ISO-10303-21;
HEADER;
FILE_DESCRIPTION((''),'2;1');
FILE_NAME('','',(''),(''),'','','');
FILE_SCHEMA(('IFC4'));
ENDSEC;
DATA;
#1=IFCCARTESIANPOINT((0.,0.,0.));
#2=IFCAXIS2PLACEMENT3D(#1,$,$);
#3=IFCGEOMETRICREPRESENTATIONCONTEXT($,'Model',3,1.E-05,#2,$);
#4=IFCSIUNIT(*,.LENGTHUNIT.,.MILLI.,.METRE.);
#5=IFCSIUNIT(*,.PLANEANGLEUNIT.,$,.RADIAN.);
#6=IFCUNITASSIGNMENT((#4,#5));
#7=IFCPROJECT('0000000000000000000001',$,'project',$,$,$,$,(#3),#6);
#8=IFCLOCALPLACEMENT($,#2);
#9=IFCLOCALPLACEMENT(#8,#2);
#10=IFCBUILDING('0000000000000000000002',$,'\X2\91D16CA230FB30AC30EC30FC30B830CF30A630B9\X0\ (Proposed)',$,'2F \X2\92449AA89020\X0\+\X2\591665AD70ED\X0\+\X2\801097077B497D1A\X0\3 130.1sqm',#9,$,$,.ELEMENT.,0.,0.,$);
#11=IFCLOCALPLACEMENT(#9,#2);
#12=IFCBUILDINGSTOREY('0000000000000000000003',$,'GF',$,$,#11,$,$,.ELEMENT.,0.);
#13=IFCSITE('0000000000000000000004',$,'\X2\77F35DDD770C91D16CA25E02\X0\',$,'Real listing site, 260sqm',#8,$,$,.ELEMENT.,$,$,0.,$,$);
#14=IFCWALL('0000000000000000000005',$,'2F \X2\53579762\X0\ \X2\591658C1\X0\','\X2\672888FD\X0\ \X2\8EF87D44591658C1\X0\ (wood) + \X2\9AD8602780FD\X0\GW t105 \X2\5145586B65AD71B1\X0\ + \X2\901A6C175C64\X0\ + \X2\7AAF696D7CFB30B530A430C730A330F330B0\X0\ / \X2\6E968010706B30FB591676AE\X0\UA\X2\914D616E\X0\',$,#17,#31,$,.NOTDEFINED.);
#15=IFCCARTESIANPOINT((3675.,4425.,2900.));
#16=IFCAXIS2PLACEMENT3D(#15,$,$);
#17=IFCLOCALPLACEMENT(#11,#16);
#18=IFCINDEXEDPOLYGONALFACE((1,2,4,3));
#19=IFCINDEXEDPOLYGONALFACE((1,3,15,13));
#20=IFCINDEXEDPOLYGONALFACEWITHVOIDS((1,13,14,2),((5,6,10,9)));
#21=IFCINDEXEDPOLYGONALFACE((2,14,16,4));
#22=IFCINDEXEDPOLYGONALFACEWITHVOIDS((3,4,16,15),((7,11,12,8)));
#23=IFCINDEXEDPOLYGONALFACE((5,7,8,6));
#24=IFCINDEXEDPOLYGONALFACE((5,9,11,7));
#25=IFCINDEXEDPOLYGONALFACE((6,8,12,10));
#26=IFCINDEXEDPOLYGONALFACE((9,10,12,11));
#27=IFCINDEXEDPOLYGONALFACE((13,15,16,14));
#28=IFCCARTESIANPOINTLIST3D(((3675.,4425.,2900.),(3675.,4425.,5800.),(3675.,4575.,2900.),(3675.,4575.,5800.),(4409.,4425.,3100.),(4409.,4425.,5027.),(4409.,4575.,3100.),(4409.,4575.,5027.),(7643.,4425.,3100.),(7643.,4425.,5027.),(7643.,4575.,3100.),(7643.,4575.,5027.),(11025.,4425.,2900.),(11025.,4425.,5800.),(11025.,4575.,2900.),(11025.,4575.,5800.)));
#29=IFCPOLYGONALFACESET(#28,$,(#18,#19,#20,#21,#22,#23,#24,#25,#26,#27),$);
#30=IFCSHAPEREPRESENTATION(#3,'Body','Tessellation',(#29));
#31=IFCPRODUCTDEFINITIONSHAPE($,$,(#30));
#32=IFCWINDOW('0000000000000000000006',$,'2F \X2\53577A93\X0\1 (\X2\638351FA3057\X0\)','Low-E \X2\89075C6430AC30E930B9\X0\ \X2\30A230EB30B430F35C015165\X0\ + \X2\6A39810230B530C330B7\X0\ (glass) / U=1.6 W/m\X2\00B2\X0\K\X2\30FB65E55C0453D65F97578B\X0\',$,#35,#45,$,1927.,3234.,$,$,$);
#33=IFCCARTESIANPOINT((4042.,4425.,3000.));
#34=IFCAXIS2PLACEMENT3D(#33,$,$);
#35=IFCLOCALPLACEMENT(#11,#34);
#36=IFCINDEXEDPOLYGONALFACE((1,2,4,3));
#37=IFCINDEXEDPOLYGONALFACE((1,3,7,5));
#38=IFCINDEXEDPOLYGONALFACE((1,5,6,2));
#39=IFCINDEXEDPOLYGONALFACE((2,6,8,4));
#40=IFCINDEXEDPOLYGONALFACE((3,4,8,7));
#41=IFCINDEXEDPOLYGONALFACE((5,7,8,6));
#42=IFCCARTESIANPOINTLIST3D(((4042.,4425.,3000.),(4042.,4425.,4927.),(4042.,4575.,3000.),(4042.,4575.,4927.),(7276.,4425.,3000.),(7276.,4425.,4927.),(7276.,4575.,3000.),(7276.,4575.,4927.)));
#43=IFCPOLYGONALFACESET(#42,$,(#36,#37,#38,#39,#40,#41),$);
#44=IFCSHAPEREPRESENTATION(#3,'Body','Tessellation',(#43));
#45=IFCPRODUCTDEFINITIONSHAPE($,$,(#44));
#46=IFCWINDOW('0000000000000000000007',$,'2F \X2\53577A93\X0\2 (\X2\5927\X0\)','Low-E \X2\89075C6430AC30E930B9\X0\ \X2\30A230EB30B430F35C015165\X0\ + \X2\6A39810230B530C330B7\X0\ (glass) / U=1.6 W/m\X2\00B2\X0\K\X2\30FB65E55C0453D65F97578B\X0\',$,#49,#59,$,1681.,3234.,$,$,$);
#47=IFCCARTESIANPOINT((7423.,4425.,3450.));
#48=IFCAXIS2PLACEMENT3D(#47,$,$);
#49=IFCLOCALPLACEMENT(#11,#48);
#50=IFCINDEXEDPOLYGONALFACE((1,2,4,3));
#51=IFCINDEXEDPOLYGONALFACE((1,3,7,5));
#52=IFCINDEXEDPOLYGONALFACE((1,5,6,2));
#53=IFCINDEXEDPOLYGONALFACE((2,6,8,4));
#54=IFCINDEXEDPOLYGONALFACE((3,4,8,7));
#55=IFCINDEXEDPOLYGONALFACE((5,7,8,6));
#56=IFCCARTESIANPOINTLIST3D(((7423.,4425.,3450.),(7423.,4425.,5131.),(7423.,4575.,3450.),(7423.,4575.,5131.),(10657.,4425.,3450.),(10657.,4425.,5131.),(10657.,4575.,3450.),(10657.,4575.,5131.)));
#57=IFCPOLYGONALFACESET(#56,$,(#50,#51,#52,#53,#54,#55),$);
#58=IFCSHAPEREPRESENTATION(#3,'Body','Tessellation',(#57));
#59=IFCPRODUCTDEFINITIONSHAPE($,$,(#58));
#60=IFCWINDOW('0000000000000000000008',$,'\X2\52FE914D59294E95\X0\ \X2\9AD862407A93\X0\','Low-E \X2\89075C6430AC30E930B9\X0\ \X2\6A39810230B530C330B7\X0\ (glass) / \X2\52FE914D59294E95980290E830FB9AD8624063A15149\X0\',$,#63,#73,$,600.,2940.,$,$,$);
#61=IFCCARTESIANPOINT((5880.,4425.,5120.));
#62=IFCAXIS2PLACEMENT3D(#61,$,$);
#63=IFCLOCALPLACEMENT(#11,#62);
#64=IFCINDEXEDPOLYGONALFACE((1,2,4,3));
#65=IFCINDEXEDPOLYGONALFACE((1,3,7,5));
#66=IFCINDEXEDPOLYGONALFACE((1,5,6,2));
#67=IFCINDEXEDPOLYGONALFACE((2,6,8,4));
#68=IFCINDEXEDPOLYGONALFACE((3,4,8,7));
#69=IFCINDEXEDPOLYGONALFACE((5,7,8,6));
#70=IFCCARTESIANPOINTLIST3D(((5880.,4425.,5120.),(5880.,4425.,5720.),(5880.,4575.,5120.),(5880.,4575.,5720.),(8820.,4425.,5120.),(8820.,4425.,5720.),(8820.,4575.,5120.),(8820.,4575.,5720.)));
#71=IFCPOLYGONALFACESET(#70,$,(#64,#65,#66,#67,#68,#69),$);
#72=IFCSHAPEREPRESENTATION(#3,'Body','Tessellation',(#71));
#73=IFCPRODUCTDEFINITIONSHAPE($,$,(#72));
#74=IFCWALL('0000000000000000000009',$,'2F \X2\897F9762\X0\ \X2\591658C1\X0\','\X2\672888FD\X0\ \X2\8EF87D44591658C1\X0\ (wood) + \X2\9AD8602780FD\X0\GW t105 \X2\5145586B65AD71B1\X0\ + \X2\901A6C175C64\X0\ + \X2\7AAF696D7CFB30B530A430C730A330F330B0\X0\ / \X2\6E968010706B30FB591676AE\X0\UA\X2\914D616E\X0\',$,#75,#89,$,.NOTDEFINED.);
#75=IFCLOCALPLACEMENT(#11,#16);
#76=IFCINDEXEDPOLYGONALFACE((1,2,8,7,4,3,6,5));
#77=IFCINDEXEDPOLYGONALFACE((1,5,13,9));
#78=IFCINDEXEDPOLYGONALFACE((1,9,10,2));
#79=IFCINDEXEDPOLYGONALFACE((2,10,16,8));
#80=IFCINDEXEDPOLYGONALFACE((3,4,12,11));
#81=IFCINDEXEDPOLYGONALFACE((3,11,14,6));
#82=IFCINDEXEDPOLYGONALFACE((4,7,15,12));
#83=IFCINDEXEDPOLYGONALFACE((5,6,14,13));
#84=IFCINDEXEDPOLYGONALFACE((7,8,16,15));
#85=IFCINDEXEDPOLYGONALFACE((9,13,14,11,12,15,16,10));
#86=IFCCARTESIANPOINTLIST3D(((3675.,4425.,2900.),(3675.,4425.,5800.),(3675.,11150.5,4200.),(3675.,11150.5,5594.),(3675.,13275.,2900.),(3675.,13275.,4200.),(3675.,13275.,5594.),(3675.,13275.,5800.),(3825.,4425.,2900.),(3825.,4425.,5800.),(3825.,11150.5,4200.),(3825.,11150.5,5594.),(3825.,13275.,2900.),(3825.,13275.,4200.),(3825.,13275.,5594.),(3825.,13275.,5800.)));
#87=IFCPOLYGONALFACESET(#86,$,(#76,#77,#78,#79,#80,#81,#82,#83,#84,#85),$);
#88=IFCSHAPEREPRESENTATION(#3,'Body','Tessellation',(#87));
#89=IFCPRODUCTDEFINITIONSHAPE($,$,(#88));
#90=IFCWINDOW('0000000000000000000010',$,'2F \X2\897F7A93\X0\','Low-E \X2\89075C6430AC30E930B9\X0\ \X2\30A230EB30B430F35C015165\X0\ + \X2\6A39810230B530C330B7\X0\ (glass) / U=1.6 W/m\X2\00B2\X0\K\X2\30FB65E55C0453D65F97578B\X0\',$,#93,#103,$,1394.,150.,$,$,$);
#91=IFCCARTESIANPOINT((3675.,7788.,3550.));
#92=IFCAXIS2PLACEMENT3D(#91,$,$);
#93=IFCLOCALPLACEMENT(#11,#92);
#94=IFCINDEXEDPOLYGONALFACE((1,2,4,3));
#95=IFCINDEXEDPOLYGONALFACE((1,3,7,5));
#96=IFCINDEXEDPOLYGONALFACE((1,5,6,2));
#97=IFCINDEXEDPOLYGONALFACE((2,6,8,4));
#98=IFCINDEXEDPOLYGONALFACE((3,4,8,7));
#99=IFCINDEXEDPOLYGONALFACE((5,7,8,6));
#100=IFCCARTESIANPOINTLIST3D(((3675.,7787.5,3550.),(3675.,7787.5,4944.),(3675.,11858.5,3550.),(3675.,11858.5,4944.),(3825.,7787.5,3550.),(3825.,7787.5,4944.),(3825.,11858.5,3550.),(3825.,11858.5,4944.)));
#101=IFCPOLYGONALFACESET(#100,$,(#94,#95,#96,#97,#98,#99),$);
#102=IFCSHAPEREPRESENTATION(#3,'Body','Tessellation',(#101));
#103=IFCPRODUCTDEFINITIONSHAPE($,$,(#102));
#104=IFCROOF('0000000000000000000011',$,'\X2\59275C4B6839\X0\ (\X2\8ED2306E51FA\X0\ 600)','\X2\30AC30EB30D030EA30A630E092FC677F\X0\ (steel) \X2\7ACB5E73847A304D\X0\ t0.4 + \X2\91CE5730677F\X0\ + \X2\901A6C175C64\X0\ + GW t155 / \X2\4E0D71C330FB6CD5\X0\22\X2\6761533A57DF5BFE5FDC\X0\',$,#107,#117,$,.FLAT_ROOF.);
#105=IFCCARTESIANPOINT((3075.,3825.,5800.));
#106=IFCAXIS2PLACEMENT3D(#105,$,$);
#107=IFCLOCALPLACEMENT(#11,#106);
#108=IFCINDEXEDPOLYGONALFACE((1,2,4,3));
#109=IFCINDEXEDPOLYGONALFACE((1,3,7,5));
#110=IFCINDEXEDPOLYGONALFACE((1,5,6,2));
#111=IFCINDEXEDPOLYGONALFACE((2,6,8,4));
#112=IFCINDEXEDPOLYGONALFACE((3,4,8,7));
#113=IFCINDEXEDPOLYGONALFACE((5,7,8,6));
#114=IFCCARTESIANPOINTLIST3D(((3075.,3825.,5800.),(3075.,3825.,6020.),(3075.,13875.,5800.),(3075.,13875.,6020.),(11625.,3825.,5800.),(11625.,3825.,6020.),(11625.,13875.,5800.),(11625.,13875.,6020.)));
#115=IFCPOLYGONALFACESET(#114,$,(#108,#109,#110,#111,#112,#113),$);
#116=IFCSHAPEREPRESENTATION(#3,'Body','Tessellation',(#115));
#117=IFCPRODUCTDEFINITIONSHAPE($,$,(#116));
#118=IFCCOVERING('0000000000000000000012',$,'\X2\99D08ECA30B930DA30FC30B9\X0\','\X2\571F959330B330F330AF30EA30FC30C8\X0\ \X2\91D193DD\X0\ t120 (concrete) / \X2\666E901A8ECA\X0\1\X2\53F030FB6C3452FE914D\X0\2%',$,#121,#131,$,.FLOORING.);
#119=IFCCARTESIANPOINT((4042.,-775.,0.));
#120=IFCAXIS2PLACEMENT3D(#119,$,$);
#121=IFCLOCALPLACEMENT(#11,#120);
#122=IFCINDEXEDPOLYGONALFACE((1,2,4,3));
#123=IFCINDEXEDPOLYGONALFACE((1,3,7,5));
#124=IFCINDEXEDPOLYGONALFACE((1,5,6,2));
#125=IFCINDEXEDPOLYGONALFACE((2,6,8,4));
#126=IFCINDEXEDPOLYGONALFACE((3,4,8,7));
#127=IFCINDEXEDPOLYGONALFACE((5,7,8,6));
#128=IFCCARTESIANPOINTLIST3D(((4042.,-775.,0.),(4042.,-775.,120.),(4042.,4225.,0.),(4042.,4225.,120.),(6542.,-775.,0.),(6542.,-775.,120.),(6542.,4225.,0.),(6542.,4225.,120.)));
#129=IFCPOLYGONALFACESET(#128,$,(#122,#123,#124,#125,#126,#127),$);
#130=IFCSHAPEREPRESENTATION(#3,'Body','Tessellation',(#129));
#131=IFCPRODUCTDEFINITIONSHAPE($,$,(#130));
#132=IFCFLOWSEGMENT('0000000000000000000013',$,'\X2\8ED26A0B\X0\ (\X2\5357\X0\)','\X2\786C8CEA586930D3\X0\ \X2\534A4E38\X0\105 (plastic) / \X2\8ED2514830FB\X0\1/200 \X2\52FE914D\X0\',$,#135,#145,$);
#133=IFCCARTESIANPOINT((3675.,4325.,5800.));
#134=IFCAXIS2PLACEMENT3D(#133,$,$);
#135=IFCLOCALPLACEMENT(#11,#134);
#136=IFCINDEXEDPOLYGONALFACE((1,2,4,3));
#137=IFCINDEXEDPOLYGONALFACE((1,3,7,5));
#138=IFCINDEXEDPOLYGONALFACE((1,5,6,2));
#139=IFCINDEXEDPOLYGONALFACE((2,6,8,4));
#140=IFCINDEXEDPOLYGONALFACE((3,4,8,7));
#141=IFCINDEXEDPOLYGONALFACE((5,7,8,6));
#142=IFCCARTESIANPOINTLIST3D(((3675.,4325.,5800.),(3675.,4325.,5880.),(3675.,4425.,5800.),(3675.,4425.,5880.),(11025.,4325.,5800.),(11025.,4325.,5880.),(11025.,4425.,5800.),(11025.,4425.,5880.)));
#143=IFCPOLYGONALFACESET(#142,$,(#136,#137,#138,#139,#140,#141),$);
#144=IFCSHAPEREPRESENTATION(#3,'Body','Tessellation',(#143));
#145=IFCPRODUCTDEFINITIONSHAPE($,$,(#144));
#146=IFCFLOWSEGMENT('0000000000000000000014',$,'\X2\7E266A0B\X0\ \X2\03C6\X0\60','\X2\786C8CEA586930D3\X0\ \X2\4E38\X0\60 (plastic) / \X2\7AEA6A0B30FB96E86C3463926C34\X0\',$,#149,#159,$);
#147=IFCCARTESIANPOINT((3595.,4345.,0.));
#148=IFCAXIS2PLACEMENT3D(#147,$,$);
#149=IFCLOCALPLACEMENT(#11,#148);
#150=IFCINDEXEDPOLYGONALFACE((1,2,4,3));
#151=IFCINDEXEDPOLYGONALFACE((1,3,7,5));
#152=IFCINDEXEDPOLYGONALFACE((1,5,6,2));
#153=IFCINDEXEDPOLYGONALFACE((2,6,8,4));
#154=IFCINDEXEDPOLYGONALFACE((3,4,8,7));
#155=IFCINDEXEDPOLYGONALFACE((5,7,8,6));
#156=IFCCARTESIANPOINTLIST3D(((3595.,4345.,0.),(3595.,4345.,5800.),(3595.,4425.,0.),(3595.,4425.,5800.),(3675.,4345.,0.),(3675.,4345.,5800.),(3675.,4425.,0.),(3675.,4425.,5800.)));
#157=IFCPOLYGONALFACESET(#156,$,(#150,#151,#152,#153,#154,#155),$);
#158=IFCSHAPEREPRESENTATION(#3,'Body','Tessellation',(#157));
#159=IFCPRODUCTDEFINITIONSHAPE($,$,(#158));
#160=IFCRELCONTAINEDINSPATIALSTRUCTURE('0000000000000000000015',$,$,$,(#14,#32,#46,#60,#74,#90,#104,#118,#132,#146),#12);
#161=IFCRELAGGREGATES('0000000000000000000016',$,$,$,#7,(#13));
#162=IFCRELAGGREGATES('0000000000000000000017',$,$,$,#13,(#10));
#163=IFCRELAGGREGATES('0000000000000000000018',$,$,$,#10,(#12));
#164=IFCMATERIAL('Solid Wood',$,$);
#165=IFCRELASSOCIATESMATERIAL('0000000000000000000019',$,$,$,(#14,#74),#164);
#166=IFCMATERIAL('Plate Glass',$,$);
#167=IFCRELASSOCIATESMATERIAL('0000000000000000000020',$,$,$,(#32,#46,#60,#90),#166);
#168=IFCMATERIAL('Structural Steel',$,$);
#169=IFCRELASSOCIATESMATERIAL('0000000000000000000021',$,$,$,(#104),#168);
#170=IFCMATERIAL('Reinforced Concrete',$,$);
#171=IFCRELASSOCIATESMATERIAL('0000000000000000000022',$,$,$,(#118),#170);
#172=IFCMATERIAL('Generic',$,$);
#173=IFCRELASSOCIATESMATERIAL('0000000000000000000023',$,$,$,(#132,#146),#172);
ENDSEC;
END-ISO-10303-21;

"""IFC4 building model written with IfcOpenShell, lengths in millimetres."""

from ifc_helpers import new_model, si_unit, frame, frame_2d, origin, place, context, project, spatial, rectangle, extrude, material, element, fill, save


model = new_model("IFC4")

# Units and contexts
model_context = context("Model", 3, precision=1e-05, world=origin())
ifc_project = project(units=[si_unit("LENGTHUNIT", "METRE", prefix="MILLI"), si_unit("PLANEANGLEUNIT", "RADIAN")], contexts=[model_context])

# Site, building, storey
site_placement = place(None, origin())
site = spatial("IfcSite", under=ifc_project, at=site_placement, Name="石川県金沢市", ObjectType="Real listing site, 260sqm", CompositionType="ELEMENT", RefElevation=0.0)
building_placement = place(site_placement, origin())
building = spatial("IfcBuilding", under=site, at=building_placement, Name="金沢・ガレージハウス (Proposed)", ObjectType="2F 鉄骨造+外断热+耐震等級3 130.1sqm", CompositionType="ELEMENT", ElevationOfRefHeight=0.0, ElevationOfTerrain=0.0)
storey_placement = place(building_placement, origin())
storey = spatial("IfcBuildingStorey", under=building, at=storey_placement, Name="GF", CompositionType="ELEMENT", Elevation=0.0)

# Shared definitions
ifc_material_1 = material(Name="Solid Wood")

# Shared definitions
ifc_material_2 = material(Name="Reinforced Concrete")

# Shared definitions
ifc_material_3 = material(Name="Plate Glass")

# Wall, openings, windows
wall_1_placement = place(storey_placement, frame((3675.0, 4425.0, 2900.0)))
wall_1 = element("IfcWall", 1, at=wall_1_placement, inside=storey, material=ifc_material_1, Name="2F 南面 外壁", Description="木製 軸組外壁 (wood) + 高性能GW t105 充填断熱 + 通気層 + 窯業系サイディング / 準耐火・外皮UA配慮", PredefinedType="NOTDEFINED", context=model_context, shape_type="SweptSolid", body=[
    extrude(rectangle(XDim=7350.0, YDim=150.0, at=frame_2d((3675.0, 75.0))), frame((3675.0, 4425.0, 2900.0)), (0.0, 0.0, 1.0), 2900.0),
])
opening_1_placement = place(storey_placement, frame((4042.0, 4425.0, 3000.0)))
opening_1 = element("IfcOpeningElement", 2, at=opening_1_placement, cuts=wall_1, PredefinedType="NOTDEFINED", context=model_context, shape_type="SweptSolid", body=[
    extrude(rectangle(XDim=3234.0, YDim=150.0, at=frame_2d((1617.0, 75.0))), frame((4042.0, 4425.0, 3000.0)), (0.0, 0.0, 1.0), 1927.0),
])
opening_2_placement = place(storey_placement, frame((7423.0, 4425.0, 3450.0)))
opening_2 = element("IfcOpeningElement", 3, at=opening_2_placement, cuts=wall_1, PredefinedType="NOTDEFINED", context=model_context, shape_type="SweptSolid", body=[
    extrude(rectangle(XDim=3234.0, YDim=150.0, at=frame_2d((1617.0, 75.0))), frame((7423.0, 4425.0, 3450.0)), (0.0, 0.0, 1.0), 1681.0),
])
opening_3_placement = place(storey_placement, frame((5880.0, 4425.0, 5120.0)))
opening_3 = element("IfcOpeningElement", 4, at=opening_3_placement, cuts=wall_1, PredefinedType="NOTDEFINED", context=model_context, shape_type="SweptSolid", body=[
    extrude(rectangle(XDim=2940.0, YDim=150.0, at=frame_2d((1470.0, 75.0))), frame((5880.0, 4425.0, 5120.0)), (0.0, 0.0, 1.0), 600.0),
])
window_1_placement = place(storey_placement, frame((4042.0, 4425.0, 3000.0)))
window_1 = element("IfcWindow", 5, at=window_1_placement, inside=storey, material=ifc_material_3, Name="2F 南窓1 (掃出し)", Description="Low-E 複層ガラス アルゴン封入 + 樹脂サッシ (glass) / U=1.6 W/m²K・日射取得型", OverallHeight=1927.0, OverallWidth=3234.0, context=model_context, shape_type="SweptSolid", body=[
    extrude(rectangle(XDim=3234.0, YDim=150.0, at=frame_2d((1617.0, 75.0))), frame((4042.0, 4425.0, 3000.0)), (0.0, 0.0, 1.0), 1927.0),
])
fill(opening_1, window_1)
window_2_placement = place(storey_placement, frame((7423.0, 4425.0, 3450.0)))
window_2 = element("IfcWindow", 6, at=window_2_placement, inside=storey, material=ifc_material_3, Name="2F 南窓2 (大)", Description="Low-E 複層ガラス アルゴン封入 + 樹脂サッシ (glass) / U=1.6 W/m²K・日射取得型", OverallHeight=1681.0, OverallWidth=3234.0, context=model_context, shape_type="SweptSolid", body=[
    extrude(rectangle(XDim=3234.0, YDim=150.0, at=frame_2d((1617.0, 75.0))), frame((7423.0, 4425.0, 3450.0)), (0.0, 0.0, 1.0), 1681.0),
])
fill(opening_2, window_2)
window_3_placement = place(storey_placement, frame((5880.0, 4425.0, 5120.0)))
window_3 = element("IfcWindow", 7, at=window_3_placement, inside=storey, material=ifc_material_3, Name="勾配天井 高所窓", Description="Low-E 複層ガラス 樹脂サッシ (glass) / 勾配天井頂部・高所採光", OverallHeight=600.0, OverallWidth=2940.0, context=model_context, shape_type="SweptSolid", body=[
    extrude(rectangle(XDim=2940.0, YDim=150.0, at=frame_2d((1470.0, 75.0))), frame((5880.0, 4425.0, 5120.0)), (0.0, 0.0, 1.0), 600.0),
])
fill(opening_3, window_3)

# Wall, opening, window
wall_2_placement = place(storey_placement, frame((3675.0, 4425.0, 2900.0)))
wall_2 = element("IfcWall", 8, at=wall_2_placement, inside=storey, material=ifc_material_1, Name="2F 西面 外壁", Description="木製 軸組外壁 (wood) + 高性能GW t105 充填断熱 + 通気層 + 窯業系サイディング / 準耐火・外皮UA配慮", PredefinedType="NOTDEFINED", context=model_context, shape_type="SweptSolid", body=[
    extrude(rectangle(XDim=150.0, YDim=8850.0, at=frame_2d((75.0, 4425.0))), frame((3675.0, 4425.0, 2900.0)), (0.0, 0.0, 1.0), 2900.0),
])
opening_4_placement = place(storey_placement, frame((3675.0, 7788.0, 3550.0)))
opening_4 = element("IfcOpeningElement", 9, at=opening_4_placement, cuts=wall_2, PredefinedType="NOTDEFINED", context=model_context, shape_type="SweptSolid", body=[
    extrude(rectangle(XDim=150.0, YDim=4071.0, at=frame_2d((75.0, 2035.0))), frame((3675.0, 7788.0, 3550.0)), (0.0, 0.0, 1.0), 1394.0),
])
window_4_placement = place(storey_placement, frame((3675.0, 7788.0, 3550.0)))
window_4 = element("IfcWindow", 10, at=window_4_placement, inside=storey, material=ifc_material_3, Name="2F 西窓", Description="Low-E 複層ガラス アルゴン封入 + 樹脂サッシ (glass) / U=1.6 W/m²K・日射取得型", OverallHeight=1394.0, OverallWidth=150.0, context=model_context, shape_type="SweptSolid", body=[
    extrude(rectangle(XDim=150.0, YDim=4071.0, at=frame_2d((75.0, 2035.0))), frame((3675.0, 7788.0, 3550.0)), (0.0, 0.0, 1.0), 1394.0),
])
fill(opening_4, window_4)

# Roof
ifc_material_4 = material(Name="Structural Steel")
roof_placement = place(storey_placement, frame((3075.0, 3825.0, 5800.0)))
element("IfcRoof", 11, at=roof_placement, inside=storey, material=ifc_material_4, Name="大屋根 (軒の出 600)", Description="ガルバリウム鋼板 (steel) 立平葺き t0.4 + 野地板 + 通気層 + GW t155 / 不燃・法22条区域対応", PredefinedType="FLAT_ROOF", context=model_context, shape_type="SweptSolid", body=[
    extrude(rectangle(XDim=8550.0, YDim=10050.0, at=frame_2d((4275.0, 5025.0))), frame((3075.0, 3825.0, 5800.0)), (0.0, 0.0, 1.0), 220.0),
])

# Covering
covering_placement = place(storey_placement, frame((4042.0, -775.0, 0.0)))
element("IfcCovering", 12, at=covering_placement, inside=storey, material=ifc_material_2, Name="駐車スペース", Description="土間コンクリート 金鏝 t120 (concrete) / 普通車1台・水勾配2%", PredefinedType="FLOORING", context=model_context, shape_type="SweptSolid", body=[
    extrude(rectangle(XDim=2500.0, YDim=5000.0, at=frame_2d((1250.0, 2500.0))), frame((4042.0, -775.0, 0.0)), (0.0, 0.0, 1.0), 120.0),
])

# Flow segments
ifc_material_5 = material(Name="Generic")
flow_segment_1_placement = place(storey_placement, frame((3675.0, 4325.0, 5800.0)))
element("IfcFlowSegment", 13, at=flow_segment_1_placement, inside=storey, material=ifc_material_5, Name="軒樋 (南)", Description="硬質塩ビ 半丸105 (plastic) / 軒先・1/200 勾配", context=model_context, shape_type="SweptSolid", body=[
    extrude(rectangle(XDim=7350.0, YDim=100.0, at=frame_2d((3675.0, 50.0))), frame((3675.0, 4325.0, 5800.0)), (0.0, 0.0, 1.0), 80.0),
])
flow_segment_2_placement = place(storey_placement, frame((3595.0, 4345.0, 0.0)))
element("IfcFlowSegment", 14, at=flow_segment_2_placement, inside=storey, material=ifc_material_5, Name="縦樋 φ60", Description="硬質塩ビ 丸60 (plastic) / 竪樋・雨水排水", context=model_context, shape_type="SweptSolid", body=[
    extrude(rectangle(XDim=80.0, YDim=80.0, at=frame_2d((40.0, 40.0))), frame((3595.0, 4345.0, 0.0)), (0.0, 0.0, 1.0), 5800.0),
])

save(model, "model.ifc")
